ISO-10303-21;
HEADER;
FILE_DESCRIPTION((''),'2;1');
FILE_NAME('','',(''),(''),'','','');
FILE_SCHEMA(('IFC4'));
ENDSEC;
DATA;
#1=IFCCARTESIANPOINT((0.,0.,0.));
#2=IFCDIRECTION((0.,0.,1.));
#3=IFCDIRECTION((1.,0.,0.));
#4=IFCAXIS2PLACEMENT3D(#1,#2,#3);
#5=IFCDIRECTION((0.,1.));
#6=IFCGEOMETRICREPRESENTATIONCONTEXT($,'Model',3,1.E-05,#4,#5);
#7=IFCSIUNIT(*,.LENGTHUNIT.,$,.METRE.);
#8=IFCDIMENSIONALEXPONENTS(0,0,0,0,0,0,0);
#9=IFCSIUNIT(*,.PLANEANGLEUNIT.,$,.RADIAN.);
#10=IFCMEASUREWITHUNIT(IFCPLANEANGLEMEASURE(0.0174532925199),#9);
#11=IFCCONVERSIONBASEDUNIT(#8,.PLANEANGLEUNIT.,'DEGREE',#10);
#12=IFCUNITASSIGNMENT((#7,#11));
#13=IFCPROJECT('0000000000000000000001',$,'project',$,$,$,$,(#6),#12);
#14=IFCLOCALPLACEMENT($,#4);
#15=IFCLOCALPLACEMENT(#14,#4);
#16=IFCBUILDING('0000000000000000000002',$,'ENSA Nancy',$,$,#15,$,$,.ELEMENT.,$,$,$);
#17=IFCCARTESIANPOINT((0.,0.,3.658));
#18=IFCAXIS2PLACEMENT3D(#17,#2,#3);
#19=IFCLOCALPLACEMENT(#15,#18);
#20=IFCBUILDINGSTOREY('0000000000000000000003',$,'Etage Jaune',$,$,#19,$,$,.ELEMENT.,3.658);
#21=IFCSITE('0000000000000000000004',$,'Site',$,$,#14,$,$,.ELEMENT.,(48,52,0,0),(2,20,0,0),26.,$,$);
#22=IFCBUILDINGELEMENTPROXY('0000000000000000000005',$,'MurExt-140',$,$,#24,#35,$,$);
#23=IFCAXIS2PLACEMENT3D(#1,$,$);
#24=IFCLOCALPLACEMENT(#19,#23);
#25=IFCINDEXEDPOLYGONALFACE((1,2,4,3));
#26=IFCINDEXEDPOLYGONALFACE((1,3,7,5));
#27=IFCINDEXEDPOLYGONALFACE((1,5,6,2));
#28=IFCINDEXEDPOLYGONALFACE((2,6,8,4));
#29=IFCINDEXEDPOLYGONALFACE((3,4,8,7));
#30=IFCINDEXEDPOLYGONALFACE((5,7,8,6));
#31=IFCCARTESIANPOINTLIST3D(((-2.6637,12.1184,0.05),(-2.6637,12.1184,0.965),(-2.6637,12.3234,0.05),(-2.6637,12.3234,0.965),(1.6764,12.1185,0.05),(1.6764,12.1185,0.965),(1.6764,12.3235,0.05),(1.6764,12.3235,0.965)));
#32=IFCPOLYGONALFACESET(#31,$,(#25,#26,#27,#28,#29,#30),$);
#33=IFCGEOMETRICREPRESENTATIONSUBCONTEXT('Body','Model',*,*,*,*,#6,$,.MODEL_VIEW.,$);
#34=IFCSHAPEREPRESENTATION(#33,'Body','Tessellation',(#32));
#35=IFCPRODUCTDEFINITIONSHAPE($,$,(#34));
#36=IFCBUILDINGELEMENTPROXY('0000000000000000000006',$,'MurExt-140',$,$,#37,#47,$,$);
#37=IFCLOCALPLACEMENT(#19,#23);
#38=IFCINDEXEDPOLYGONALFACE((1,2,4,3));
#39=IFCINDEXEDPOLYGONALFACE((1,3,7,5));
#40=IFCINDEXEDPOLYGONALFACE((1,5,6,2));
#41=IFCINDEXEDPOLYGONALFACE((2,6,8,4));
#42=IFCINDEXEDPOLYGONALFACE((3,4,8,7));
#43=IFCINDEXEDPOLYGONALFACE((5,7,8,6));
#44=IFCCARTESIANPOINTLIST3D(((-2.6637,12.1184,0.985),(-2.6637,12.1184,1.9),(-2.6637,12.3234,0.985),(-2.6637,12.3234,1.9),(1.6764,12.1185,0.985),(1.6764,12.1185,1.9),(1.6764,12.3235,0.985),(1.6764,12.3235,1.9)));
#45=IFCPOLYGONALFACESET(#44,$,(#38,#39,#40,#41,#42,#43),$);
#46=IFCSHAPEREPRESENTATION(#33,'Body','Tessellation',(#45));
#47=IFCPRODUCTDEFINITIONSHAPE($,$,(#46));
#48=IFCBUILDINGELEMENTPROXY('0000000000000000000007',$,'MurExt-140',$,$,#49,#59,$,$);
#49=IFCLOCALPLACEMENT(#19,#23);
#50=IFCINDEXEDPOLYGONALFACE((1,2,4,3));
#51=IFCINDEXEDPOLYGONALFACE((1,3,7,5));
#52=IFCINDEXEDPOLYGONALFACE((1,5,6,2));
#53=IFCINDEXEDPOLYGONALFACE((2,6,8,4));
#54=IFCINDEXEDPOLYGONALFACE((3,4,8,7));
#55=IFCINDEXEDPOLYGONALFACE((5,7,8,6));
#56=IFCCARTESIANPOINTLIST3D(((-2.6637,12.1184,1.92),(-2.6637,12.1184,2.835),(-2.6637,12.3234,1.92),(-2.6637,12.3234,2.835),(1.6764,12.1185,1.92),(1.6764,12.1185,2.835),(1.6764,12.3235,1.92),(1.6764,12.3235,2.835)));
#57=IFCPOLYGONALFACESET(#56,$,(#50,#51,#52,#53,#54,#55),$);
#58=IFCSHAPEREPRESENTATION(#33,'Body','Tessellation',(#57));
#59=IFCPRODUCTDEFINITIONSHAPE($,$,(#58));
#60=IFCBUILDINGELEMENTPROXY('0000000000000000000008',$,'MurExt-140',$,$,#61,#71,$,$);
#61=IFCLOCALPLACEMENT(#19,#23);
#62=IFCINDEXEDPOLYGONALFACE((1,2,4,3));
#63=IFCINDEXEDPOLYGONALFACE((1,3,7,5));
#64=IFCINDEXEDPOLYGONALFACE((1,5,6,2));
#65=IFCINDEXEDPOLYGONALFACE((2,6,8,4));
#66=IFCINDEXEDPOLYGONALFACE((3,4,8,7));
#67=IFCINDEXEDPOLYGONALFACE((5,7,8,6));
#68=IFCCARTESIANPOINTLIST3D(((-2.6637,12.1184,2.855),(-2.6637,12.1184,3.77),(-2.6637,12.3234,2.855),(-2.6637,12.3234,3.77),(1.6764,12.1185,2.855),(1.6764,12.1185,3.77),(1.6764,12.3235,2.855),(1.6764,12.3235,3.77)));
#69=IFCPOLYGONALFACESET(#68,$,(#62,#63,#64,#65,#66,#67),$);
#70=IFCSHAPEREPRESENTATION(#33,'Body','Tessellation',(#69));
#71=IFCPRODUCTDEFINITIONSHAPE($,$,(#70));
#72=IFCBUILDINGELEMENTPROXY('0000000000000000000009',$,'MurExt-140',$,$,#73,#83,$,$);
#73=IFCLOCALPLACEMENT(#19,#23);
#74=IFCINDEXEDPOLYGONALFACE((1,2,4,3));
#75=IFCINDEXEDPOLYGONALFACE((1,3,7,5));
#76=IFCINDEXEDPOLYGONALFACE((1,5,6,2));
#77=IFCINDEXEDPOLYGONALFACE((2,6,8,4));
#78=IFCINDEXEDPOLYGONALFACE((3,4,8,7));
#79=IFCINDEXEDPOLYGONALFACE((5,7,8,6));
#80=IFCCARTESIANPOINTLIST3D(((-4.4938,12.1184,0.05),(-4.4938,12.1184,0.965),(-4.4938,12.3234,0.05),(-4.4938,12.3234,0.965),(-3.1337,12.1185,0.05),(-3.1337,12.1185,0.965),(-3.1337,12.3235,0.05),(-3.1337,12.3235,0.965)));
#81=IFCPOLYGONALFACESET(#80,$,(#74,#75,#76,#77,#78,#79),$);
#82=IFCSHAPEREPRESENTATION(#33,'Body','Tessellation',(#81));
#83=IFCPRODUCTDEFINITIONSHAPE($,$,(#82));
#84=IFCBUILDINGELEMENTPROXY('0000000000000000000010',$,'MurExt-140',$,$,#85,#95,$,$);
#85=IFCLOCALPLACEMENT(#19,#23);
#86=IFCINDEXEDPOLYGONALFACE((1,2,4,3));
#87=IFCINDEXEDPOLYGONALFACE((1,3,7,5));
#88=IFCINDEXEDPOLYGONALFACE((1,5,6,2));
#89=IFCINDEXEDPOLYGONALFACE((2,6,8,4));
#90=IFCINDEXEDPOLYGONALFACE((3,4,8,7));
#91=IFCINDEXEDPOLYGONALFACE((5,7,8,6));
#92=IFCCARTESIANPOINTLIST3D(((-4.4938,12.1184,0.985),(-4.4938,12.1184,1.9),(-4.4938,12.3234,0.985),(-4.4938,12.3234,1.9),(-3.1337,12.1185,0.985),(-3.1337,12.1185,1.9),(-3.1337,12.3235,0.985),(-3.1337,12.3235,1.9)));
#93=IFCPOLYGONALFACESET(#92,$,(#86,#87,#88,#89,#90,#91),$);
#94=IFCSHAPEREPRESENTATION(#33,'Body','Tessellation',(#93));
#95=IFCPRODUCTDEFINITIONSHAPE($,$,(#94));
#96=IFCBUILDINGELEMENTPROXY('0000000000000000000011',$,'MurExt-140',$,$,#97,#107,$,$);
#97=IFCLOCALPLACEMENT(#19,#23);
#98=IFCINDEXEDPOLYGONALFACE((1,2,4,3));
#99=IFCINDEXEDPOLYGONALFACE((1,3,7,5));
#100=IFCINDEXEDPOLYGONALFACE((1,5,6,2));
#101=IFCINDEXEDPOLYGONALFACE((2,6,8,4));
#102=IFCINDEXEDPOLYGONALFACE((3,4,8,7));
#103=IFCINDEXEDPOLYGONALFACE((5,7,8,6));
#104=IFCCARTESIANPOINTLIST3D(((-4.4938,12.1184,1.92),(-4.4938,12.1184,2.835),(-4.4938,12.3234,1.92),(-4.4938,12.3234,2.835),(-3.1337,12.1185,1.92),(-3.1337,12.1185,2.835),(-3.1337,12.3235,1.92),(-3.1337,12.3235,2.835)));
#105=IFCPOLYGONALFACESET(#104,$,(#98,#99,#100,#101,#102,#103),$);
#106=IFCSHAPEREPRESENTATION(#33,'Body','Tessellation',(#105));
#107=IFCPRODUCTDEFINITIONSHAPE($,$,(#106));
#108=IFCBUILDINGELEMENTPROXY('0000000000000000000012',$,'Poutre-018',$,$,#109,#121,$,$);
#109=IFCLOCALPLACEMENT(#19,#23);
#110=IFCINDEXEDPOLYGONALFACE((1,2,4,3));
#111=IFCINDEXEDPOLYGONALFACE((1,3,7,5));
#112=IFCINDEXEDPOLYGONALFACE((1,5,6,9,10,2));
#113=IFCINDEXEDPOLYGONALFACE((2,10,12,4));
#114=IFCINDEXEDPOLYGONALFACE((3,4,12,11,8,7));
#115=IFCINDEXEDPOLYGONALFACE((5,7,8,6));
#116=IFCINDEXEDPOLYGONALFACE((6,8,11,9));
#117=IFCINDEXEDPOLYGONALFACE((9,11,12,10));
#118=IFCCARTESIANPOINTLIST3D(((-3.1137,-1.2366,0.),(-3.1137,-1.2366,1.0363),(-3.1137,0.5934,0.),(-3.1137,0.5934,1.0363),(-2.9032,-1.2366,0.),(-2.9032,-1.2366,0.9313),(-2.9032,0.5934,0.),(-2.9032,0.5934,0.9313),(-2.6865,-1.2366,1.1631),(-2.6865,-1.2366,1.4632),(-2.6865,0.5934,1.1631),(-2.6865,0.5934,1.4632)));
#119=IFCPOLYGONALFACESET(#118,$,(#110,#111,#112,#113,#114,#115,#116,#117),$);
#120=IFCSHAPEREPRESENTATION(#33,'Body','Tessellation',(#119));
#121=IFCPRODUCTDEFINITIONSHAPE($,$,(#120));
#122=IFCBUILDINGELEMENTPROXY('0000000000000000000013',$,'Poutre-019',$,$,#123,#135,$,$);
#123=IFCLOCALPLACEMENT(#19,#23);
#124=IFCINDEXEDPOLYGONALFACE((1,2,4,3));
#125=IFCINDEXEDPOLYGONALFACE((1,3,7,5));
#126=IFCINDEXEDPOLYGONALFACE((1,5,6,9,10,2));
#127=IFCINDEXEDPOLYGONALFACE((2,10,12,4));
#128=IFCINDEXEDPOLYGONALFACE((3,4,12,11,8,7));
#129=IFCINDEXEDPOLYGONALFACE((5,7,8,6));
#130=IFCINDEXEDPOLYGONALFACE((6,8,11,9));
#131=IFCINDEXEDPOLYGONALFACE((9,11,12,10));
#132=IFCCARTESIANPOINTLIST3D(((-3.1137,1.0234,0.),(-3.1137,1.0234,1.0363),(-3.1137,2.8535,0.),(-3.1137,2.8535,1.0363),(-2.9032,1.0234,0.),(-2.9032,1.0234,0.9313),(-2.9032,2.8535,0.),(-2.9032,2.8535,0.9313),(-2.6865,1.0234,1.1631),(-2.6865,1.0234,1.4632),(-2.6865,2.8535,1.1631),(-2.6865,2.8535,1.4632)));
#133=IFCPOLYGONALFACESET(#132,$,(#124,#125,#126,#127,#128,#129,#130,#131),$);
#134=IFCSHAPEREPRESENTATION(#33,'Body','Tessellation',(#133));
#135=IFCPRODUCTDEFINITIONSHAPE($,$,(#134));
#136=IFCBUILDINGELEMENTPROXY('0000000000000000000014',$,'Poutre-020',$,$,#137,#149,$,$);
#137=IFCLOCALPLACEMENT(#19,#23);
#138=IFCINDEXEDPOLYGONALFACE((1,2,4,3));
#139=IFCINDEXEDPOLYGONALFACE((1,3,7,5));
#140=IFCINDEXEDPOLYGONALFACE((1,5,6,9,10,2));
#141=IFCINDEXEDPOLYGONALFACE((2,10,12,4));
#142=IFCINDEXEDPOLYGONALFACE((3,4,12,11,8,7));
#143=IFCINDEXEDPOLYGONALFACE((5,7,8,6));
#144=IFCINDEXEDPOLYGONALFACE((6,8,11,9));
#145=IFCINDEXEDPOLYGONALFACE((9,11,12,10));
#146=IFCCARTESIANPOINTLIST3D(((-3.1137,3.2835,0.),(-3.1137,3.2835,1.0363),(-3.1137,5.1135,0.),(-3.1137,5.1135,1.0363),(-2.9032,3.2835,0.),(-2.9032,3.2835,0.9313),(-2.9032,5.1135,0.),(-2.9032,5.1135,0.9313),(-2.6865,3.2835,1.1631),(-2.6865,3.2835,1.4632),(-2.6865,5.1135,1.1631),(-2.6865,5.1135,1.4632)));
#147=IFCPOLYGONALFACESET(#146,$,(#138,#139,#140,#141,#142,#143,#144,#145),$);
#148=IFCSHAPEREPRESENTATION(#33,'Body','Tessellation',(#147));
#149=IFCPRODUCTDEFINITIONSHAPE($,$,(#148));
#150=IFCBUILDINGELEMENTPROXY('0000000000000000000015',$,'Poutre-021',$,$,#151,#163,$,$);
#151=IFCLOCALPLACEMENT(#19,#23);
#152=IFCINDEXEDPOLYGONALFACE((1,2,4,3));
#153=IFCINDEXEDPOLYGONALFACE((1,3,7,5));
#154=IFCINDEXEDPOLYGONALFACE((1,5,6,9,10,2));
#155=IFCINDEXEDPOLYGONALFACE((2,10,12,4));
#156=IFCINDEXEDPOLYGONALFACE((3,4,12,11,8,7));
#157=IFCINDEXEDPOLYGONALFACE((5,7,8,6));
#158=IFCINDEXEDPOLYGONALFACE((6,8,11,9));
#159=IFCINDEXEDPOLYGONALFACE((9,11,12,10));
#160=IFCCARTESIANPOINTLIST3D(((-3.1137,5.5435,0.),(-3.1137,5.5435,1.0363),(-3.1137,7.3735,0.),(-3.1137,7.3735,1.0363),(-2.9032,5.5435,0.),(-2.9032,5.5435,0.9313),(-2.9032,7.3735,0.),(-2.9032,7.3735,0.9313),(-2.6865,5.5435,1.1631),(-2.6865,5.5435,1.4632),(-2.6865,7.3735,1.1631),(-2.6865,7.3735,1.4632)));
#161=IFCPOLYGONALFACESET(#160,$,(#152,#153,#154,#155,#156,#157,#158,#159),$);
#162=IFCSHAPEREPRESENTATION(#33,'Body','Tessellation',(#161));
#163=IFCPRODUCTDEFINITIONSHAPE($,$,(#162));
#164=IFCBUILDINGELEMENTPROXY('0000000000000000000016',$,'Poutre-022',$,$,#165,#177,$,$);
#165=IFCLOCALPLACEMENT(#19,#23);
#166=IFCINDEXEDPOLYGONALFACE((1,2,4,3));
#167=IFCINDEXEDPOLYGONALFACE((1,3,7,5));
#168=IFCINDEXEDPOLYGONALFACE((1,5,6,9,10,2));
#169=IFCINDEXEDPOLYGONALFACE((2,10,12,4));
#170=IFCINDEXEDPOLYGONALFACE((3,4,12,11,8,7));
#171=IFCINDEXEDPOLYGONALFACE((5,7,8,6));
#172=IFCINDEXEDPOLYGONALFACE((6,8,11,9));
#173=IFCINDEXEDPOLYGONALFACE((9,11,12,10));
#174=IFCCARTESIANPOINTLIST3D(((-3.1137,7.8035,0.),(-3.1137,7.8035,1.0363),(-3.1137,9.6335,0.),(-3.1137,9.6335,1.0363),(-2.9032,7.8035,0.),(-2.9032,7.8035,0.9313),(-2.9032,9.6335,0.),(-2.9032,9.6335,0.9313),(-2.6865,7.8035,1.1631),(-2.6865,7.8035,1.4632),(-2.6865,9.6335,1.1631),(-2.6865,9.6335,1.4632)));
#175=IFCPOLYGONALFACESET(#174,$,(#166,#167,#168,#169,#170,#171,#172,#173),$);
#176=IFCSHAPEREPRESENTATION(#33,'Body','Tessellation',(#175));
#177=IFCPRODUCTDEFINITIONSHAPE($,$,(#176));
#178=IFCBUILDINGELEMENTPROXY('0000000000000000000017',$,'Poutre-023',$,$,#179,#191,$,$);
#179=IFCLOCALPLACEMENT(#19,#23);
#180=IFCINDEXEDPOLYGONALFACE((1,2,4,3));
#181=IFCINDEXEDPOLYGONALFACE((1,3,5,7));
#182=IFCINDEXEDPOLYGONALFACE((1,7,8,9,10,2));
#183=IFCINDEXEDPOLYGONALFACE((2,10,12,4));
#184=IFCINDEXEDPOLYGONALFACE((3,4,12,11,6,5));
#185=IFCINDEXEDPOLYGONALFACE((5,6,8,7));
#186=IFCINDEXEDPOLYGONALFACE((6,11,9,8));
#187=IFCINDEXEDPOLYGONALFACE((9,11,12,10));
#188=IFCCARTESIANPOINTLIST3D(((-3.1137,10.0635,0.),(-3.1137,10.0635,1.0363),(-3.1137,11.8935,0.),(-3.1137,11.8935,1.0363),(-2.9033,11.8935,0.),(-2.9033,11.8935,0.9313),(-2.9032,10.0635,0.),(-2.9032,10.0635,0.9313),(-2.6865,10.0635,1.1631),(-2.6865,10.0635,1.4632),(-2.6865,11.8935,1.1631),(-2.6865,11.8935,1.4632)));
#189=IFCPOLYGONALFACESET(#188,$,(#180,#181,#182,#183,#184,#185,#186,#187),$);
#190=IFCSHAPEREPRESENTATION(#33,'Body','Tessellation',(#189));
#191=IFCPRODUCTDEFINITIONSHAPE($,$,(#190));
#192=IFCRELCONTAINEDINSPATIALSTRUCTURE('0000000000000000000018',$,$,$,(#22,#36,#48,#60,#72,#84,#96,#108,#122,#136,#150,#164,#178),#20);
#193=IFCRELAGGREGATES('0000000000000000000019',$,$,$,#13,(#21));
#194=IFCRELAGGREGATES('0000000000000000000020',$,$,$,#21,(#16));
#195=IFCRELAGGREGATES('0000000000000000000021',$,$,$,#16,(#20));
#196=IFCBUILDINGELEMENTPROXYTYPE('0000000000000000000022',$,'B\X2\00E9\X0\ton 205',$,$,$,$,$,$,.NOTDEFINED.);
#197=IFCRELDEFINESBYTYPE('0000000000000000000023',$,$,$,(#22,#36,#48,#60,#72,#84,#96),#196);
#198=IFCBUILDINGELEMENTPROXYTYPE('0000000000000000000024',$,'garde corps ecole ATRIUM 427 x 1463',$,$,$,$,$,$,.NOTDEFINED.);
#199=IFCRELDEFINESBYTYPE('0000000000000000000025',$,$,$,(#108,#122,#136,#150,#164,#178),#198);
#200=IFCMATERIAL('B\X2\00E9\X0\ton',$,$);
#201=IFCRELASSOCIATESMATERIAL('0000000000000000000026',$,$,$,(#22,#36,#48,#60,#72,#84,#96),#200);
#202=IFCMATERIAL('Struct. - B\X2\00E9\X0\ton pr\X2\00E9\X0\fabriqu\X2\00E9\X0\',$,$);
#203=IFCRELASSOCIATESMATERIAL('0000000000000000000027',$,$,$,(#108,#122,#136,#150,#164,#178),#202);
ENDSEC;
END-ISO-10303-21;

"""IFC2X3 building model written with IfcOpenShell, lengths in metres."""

from ifc_helpers import new_model, entity, si_unit, converted_unit, direction, frame, origin_with_axes, place, context, subcontext, project, spatial, polyline, outline, extrude, material, type_object, element, save


model = new_model("IFC2X3")

# Units and contexts
model_context = context("Model", 3, precision=1e-05, world=origin_with_axes(), true_north=direction((0.0, 1.0)))
body_context = subcontext(model_context, "Body", "Model", "MODEL_VIEW")
ifc_project = project(units=[si_unit("LENGTHUNIT", "METRE"), converted_unit("PLANEANGLEUNIT", "DEGREE", entity("IfcPlaneAngleMeasure", 0.0174532925199), si_unit("PLANEANGLEUNIT", "RADIAN"), dimensions=[0, 0, 0, 0, 0, 0, 0])], contexts=[model_context])

# Site, building, storey
site_placement = place(None, origin_with_axes())
site = spatial("IfcSite", under=ifc_project, at=site_placement, Name="Site", CompositionType="ELEMENT", RefLatitude=(48, 52, 0, 0), RefLongitude=(2, 20, 0, 0), RefElevation=26.0)
building_placement = place(site_placement, origin_with_axes())
building = spatial("IfcBuilding", under=site, at=building_placement, Name="ENSA Nancy", CompositionType="ELEMENT")
storey_placement = place(building_placement, frame((0.0, 0.0, 3.658), z_axis=(0.0, 0.0, 1.0), x_axis=(1.0, 0.0, 0.0)))
storey = spatial("IfcBuildingStorey", under=building, at=storey_placement, Name="Etage Jaune", CompositionType="ELEMENT", Elevation=3.658)

# Shared definitions
ifc_material_1 = material(Name="Béton")

# Building element proxies
building_element_proxy_type_1 = type_object("IfcBuildingElementProxyType", Name="Béton 205", PredefinedType="NOTDEFINED")
proxy_1_placement = place(storey_placement, frame((-2.6637, 12.3234, 0.05), z_axis=(0.0, 0.0, 1.0), x_axis=(1.0, 0.000011, 0.0)))
element("IfcBuildingElementProxy", 1, at=proxy_1_placement, inside=storey, type_object=building_element_proxy_type_1, material=ifc_material_1, Name="MurExt-140", context=body_context, shape_type="SweptSolid", body=[
    extrude(outline(polyline([(0.0, -0.205), (4.3401, -0.205), (4.3401, 0.0), (0.0, 0.0), (0.0, -0.205)])), origin_with_axes(), (0.0, 0.0, 1.0), 0.915),
])
proxy_2_placement = place(storey_placement, frame((-2.6637, 12.3234, 0.985), z_axis=(0.0, 0.0, 1.0), x_axis=(1.0, 0.000011, 0.0)))
element("IfcBuildingElementProxy", 2, at=proxy_2_placement, inside=storey, type_object=building_element_proxy_type_1, material=ifc_material_1, Name="MurExt-140", context=body_context, shape_type="SweptSolid", body=[
    extrude(outline(polyline([(0.0, -0.205), (4.3401, -0.205), (4.3401, 0.0), (0.0, 0.0), (0.0, -0.205)])), origin_with_axes(), (0.0, 0.0, 1.0), 0.915),
])
for number, where, z_axis, x_axis, name in (
    (3, (-2.6637, 12.3234, 1.92), (0.0, 0.0, 1.0), (1.0, 0.000011, 0.0), "MurExt-140"),
    (4, (-2.6637, 12.3234, 2.855), (0.0, 0.0, 1.0), (1.0, 0.000011, 0.0), "MurExt-140"),
):
    element("IfcBuildingElementProxy", number, at=place(storey_placement, frame(where, z_axis=z_axis, x_axis=x_axis)), inside=storey, type_object=building_element_proxy_type_1, material=ifc_material_1, Name=name, context=body_context, shape_type="SweptSolid", body=[
        extrude(outline(polyline([(0.0, -0.205), (4.3401, -0.205), (4.3401, 0.0), (0.0, 0.0), (0.0, -0.205)])), origin_with_axes(), (0.0, 0.0, 1.0), 0.915),
    ])
for number, where, z_axis, x_axis, name in (
    (5, (-4.4938, 12.3234, 0.05), (0.0, 0.0, 1.0), (1.0, 0.000034, 0.0), "MurExt-140"),
    (6, (-4.4938, 12.3234, 0.985), (0.0, 0.0, 1.0), (1.0, 0.000034, 0.0), "MurExt-140"),
    (7, (-4.4938, 12.3234, 1.92), (0.0, 0.0, 1.0), (1.0, 0.000034, 0.0), "MurExt-140"),
):
    element("IfcBuildingElementProxy", number, at=place(storey_placement, frame(where, z_axis=z_axis, x_axis=x_axis)), inside=storey, type_object=building_element_proxy_type_1, material=ifc_material_1, Name=name, context=body_context, shape_type="SweptSolid", body=[
        extrude(outline(polyline([(0.0, -0.205), (1.3601, -0.205), (1.3601, 0.0), (0.0, 0.0), (0.0, -0.205)])), origin_with_axes(), (0.0, 0.0, 1.0), 0.915),
    ])
ifc_material_2 = material(Name="Struct. - Béton préfabriqué")
building_element_proxy_type_2 = type_object("IfcBuildingElementProxyType", Name="garde corps ecole ATRIUM 427 x 1463", PredefinedType="NOTDEFINED")
proxy_3_placement = place(storey_placement, frame((-3.1137, -1.2366, 0.0), z_axis=(0.0, 0.0, 1.0), x_axis=(1.0, 0.0, 0.0)))
element("IfcBuildingElementProxy", 8, at=proxy_3_placement, inside=storey, type_object=building_element_proxy_type_2, material=ifc_material_2, Name="Poutre-018", context=body_context, shape_type="SweptSolid", body=[
    extrude(outline(polyline([(0.0, 1.0363), (0.0, 0.0), (0.2105, 0.0), (0.2105, 0.9313), (0.4272, 1.1631), (0.4272, 1.4632), (0.0, 1.0363)])), frame((0.0, 1.83, 0.0), z_axis=(0.0, -1.0, 0.0), x_axis=(1.0, 0.0, 0.0)), (0.0, 0.0, 1.0), 1.83),
])
proxy_4_placement = place(storey_placement, frame((-3.1137, 1.0234, 0.0), z_axis=(0.0, 0.0, 1.0), x_axis=(1.0, 0.0, 0.0)))
element("IfcBuildingElementProxy", 9, at=proxy_4_placement, inside=storey, type_object=building_element_proxy_type_2, material=ifc_material_2, Name="Poutre-019", context=body_context, shape_type="SweptSolid", body=[
    extrude(outline(polyline([(0.0, 1.0363), (0.0, 0.0), (0.2105, 0.0), (0.2105, 0.9313), (0.4272, 1.1631), (0.4272, 1.4632), (0.0, 1.0363)])), frame((0.0, 1.83, 0.0), z_axis=(0.0, -1.0, 0.0), x_axis=(1.0, 0.0, 0.0)), (0.0, 0.0, 1.0), 1.83),
])
proxy_5_placement = place(storey_placement, frame((-3.1137, 3.2835, 0.0), z_axis=(0.0, 0.0, 1.0), x_axis=(1.0, 0.0, 0.0)))
element("IfcBuildingElementProxy", 10, at=proxy_5_placement, inside=storey, type_object=building_element_proxy_type_2, material=ifc_material_2, Name="Poutre-020", context=body_context, shape_type="SweptSolid", body=[
    extrude(outline(polyline([(0.0, 1.0363), (0.0, 0.0), (0.2105, 0.0), (0.2105, 0.9313), (0.4272, 1.1631), (0.4272, 1.4632), (0.0, 1.0363)])), frame((0.0, 1.83, 0.0), z_axis=(0.0, -1.0, 0.0), x_axis=(1.0, 0.0, 0.0)), (0.0, 0.0, 1.0), 1.83),
])
proxy_6_placement = place(storey_placement, frame((-3.1137, 5.5435, 0.0), z_axis=(0.0, 0.0, 1.0), x_axis=(1.0, 0.0, 0.0)))
element("IfcBuildingElementProxy", 11, at=proxy_6_placement, inside=storey, type_object=building_element_proxy_type_2, material=ifc_material_2, Name="Poutre-021", context=body_context, shape_type="SweptSolid", body=[
    extrude(outline(polyline([(0.0, 1.0363), (0.0, 0.0), (0.2105, 0.0), (0.2105, 0.9313), (0.4272, 1.1631), (0.4272, 1.4632), (0.0, 1.0363)])), frame((0.0, 1.83, 0.0), z_axis=(0.0, -1.0, 0.0), x_axis=(1.0, 0.0, 0.0)), (0.0, 0.0, 1.0), 1.83),
])
proxy_7_placement = place(storey_placement, frame((-3.1137, 7.8035, 0.0), z_axis=(0.0, 0.0, 1.0), x_axis=(1.0, 0.0, 0.0)))
element("IfcBuildingElementProxy", 12, at=proxy_7_placement, inside=storey, type_object=building_element_proxy_type_2, material=ifc_material_2, Name="Poutre-022", context=body_context, shape_type="SweptSolid", body=[
    extrude(outline(polyline([(0.0, 1.0363), (0.0, 0.0), (0.2105, 0.0), (0.2105, 0.9313), (0.4272, 1.1631), (0.4272, 1.4632), (0.0, 1.0363)])), frame((0.0, 1.83, 0.0), z_axis=(0.0, -1.0, 0.0), x_axis=(1.0, 0.0, 0.0)), (0.0, 0.0, 1.0), 1.83),
])
proxy_8_placement = place(storey_placement, frame((-3.1137, 10.0635, 0.0), z_axis=(0.0, 0.0, 1.0), x_axis=(1.0, 0.000024, 0.0)))
element("IfcBuildingElementProxy", 13, at=proxy_8_placement, inside=storey, type_object=building_element_proxy_type_2, material=ifc_material_2, Name="Poutre-023", context=body_context, shape_type="SweptSolid", body=[
    extrude(outline(polyline([(0.0, 1.0363), (0.0, 0.0), (0.2105, 0.0), (0.2105, 0.9313), (0.4272, 1.1631), (0.4272, 1.4632), (0.0, 1.0363)])), frame((0.0, 1.83, 0.0), z_axis=(0.0, -1.0, 0.0), x_axis=(1.0, 0.0, 0.0)), (0.0, 0.0, 1.0), 1.83),
])

save(model, "model.ifc")
